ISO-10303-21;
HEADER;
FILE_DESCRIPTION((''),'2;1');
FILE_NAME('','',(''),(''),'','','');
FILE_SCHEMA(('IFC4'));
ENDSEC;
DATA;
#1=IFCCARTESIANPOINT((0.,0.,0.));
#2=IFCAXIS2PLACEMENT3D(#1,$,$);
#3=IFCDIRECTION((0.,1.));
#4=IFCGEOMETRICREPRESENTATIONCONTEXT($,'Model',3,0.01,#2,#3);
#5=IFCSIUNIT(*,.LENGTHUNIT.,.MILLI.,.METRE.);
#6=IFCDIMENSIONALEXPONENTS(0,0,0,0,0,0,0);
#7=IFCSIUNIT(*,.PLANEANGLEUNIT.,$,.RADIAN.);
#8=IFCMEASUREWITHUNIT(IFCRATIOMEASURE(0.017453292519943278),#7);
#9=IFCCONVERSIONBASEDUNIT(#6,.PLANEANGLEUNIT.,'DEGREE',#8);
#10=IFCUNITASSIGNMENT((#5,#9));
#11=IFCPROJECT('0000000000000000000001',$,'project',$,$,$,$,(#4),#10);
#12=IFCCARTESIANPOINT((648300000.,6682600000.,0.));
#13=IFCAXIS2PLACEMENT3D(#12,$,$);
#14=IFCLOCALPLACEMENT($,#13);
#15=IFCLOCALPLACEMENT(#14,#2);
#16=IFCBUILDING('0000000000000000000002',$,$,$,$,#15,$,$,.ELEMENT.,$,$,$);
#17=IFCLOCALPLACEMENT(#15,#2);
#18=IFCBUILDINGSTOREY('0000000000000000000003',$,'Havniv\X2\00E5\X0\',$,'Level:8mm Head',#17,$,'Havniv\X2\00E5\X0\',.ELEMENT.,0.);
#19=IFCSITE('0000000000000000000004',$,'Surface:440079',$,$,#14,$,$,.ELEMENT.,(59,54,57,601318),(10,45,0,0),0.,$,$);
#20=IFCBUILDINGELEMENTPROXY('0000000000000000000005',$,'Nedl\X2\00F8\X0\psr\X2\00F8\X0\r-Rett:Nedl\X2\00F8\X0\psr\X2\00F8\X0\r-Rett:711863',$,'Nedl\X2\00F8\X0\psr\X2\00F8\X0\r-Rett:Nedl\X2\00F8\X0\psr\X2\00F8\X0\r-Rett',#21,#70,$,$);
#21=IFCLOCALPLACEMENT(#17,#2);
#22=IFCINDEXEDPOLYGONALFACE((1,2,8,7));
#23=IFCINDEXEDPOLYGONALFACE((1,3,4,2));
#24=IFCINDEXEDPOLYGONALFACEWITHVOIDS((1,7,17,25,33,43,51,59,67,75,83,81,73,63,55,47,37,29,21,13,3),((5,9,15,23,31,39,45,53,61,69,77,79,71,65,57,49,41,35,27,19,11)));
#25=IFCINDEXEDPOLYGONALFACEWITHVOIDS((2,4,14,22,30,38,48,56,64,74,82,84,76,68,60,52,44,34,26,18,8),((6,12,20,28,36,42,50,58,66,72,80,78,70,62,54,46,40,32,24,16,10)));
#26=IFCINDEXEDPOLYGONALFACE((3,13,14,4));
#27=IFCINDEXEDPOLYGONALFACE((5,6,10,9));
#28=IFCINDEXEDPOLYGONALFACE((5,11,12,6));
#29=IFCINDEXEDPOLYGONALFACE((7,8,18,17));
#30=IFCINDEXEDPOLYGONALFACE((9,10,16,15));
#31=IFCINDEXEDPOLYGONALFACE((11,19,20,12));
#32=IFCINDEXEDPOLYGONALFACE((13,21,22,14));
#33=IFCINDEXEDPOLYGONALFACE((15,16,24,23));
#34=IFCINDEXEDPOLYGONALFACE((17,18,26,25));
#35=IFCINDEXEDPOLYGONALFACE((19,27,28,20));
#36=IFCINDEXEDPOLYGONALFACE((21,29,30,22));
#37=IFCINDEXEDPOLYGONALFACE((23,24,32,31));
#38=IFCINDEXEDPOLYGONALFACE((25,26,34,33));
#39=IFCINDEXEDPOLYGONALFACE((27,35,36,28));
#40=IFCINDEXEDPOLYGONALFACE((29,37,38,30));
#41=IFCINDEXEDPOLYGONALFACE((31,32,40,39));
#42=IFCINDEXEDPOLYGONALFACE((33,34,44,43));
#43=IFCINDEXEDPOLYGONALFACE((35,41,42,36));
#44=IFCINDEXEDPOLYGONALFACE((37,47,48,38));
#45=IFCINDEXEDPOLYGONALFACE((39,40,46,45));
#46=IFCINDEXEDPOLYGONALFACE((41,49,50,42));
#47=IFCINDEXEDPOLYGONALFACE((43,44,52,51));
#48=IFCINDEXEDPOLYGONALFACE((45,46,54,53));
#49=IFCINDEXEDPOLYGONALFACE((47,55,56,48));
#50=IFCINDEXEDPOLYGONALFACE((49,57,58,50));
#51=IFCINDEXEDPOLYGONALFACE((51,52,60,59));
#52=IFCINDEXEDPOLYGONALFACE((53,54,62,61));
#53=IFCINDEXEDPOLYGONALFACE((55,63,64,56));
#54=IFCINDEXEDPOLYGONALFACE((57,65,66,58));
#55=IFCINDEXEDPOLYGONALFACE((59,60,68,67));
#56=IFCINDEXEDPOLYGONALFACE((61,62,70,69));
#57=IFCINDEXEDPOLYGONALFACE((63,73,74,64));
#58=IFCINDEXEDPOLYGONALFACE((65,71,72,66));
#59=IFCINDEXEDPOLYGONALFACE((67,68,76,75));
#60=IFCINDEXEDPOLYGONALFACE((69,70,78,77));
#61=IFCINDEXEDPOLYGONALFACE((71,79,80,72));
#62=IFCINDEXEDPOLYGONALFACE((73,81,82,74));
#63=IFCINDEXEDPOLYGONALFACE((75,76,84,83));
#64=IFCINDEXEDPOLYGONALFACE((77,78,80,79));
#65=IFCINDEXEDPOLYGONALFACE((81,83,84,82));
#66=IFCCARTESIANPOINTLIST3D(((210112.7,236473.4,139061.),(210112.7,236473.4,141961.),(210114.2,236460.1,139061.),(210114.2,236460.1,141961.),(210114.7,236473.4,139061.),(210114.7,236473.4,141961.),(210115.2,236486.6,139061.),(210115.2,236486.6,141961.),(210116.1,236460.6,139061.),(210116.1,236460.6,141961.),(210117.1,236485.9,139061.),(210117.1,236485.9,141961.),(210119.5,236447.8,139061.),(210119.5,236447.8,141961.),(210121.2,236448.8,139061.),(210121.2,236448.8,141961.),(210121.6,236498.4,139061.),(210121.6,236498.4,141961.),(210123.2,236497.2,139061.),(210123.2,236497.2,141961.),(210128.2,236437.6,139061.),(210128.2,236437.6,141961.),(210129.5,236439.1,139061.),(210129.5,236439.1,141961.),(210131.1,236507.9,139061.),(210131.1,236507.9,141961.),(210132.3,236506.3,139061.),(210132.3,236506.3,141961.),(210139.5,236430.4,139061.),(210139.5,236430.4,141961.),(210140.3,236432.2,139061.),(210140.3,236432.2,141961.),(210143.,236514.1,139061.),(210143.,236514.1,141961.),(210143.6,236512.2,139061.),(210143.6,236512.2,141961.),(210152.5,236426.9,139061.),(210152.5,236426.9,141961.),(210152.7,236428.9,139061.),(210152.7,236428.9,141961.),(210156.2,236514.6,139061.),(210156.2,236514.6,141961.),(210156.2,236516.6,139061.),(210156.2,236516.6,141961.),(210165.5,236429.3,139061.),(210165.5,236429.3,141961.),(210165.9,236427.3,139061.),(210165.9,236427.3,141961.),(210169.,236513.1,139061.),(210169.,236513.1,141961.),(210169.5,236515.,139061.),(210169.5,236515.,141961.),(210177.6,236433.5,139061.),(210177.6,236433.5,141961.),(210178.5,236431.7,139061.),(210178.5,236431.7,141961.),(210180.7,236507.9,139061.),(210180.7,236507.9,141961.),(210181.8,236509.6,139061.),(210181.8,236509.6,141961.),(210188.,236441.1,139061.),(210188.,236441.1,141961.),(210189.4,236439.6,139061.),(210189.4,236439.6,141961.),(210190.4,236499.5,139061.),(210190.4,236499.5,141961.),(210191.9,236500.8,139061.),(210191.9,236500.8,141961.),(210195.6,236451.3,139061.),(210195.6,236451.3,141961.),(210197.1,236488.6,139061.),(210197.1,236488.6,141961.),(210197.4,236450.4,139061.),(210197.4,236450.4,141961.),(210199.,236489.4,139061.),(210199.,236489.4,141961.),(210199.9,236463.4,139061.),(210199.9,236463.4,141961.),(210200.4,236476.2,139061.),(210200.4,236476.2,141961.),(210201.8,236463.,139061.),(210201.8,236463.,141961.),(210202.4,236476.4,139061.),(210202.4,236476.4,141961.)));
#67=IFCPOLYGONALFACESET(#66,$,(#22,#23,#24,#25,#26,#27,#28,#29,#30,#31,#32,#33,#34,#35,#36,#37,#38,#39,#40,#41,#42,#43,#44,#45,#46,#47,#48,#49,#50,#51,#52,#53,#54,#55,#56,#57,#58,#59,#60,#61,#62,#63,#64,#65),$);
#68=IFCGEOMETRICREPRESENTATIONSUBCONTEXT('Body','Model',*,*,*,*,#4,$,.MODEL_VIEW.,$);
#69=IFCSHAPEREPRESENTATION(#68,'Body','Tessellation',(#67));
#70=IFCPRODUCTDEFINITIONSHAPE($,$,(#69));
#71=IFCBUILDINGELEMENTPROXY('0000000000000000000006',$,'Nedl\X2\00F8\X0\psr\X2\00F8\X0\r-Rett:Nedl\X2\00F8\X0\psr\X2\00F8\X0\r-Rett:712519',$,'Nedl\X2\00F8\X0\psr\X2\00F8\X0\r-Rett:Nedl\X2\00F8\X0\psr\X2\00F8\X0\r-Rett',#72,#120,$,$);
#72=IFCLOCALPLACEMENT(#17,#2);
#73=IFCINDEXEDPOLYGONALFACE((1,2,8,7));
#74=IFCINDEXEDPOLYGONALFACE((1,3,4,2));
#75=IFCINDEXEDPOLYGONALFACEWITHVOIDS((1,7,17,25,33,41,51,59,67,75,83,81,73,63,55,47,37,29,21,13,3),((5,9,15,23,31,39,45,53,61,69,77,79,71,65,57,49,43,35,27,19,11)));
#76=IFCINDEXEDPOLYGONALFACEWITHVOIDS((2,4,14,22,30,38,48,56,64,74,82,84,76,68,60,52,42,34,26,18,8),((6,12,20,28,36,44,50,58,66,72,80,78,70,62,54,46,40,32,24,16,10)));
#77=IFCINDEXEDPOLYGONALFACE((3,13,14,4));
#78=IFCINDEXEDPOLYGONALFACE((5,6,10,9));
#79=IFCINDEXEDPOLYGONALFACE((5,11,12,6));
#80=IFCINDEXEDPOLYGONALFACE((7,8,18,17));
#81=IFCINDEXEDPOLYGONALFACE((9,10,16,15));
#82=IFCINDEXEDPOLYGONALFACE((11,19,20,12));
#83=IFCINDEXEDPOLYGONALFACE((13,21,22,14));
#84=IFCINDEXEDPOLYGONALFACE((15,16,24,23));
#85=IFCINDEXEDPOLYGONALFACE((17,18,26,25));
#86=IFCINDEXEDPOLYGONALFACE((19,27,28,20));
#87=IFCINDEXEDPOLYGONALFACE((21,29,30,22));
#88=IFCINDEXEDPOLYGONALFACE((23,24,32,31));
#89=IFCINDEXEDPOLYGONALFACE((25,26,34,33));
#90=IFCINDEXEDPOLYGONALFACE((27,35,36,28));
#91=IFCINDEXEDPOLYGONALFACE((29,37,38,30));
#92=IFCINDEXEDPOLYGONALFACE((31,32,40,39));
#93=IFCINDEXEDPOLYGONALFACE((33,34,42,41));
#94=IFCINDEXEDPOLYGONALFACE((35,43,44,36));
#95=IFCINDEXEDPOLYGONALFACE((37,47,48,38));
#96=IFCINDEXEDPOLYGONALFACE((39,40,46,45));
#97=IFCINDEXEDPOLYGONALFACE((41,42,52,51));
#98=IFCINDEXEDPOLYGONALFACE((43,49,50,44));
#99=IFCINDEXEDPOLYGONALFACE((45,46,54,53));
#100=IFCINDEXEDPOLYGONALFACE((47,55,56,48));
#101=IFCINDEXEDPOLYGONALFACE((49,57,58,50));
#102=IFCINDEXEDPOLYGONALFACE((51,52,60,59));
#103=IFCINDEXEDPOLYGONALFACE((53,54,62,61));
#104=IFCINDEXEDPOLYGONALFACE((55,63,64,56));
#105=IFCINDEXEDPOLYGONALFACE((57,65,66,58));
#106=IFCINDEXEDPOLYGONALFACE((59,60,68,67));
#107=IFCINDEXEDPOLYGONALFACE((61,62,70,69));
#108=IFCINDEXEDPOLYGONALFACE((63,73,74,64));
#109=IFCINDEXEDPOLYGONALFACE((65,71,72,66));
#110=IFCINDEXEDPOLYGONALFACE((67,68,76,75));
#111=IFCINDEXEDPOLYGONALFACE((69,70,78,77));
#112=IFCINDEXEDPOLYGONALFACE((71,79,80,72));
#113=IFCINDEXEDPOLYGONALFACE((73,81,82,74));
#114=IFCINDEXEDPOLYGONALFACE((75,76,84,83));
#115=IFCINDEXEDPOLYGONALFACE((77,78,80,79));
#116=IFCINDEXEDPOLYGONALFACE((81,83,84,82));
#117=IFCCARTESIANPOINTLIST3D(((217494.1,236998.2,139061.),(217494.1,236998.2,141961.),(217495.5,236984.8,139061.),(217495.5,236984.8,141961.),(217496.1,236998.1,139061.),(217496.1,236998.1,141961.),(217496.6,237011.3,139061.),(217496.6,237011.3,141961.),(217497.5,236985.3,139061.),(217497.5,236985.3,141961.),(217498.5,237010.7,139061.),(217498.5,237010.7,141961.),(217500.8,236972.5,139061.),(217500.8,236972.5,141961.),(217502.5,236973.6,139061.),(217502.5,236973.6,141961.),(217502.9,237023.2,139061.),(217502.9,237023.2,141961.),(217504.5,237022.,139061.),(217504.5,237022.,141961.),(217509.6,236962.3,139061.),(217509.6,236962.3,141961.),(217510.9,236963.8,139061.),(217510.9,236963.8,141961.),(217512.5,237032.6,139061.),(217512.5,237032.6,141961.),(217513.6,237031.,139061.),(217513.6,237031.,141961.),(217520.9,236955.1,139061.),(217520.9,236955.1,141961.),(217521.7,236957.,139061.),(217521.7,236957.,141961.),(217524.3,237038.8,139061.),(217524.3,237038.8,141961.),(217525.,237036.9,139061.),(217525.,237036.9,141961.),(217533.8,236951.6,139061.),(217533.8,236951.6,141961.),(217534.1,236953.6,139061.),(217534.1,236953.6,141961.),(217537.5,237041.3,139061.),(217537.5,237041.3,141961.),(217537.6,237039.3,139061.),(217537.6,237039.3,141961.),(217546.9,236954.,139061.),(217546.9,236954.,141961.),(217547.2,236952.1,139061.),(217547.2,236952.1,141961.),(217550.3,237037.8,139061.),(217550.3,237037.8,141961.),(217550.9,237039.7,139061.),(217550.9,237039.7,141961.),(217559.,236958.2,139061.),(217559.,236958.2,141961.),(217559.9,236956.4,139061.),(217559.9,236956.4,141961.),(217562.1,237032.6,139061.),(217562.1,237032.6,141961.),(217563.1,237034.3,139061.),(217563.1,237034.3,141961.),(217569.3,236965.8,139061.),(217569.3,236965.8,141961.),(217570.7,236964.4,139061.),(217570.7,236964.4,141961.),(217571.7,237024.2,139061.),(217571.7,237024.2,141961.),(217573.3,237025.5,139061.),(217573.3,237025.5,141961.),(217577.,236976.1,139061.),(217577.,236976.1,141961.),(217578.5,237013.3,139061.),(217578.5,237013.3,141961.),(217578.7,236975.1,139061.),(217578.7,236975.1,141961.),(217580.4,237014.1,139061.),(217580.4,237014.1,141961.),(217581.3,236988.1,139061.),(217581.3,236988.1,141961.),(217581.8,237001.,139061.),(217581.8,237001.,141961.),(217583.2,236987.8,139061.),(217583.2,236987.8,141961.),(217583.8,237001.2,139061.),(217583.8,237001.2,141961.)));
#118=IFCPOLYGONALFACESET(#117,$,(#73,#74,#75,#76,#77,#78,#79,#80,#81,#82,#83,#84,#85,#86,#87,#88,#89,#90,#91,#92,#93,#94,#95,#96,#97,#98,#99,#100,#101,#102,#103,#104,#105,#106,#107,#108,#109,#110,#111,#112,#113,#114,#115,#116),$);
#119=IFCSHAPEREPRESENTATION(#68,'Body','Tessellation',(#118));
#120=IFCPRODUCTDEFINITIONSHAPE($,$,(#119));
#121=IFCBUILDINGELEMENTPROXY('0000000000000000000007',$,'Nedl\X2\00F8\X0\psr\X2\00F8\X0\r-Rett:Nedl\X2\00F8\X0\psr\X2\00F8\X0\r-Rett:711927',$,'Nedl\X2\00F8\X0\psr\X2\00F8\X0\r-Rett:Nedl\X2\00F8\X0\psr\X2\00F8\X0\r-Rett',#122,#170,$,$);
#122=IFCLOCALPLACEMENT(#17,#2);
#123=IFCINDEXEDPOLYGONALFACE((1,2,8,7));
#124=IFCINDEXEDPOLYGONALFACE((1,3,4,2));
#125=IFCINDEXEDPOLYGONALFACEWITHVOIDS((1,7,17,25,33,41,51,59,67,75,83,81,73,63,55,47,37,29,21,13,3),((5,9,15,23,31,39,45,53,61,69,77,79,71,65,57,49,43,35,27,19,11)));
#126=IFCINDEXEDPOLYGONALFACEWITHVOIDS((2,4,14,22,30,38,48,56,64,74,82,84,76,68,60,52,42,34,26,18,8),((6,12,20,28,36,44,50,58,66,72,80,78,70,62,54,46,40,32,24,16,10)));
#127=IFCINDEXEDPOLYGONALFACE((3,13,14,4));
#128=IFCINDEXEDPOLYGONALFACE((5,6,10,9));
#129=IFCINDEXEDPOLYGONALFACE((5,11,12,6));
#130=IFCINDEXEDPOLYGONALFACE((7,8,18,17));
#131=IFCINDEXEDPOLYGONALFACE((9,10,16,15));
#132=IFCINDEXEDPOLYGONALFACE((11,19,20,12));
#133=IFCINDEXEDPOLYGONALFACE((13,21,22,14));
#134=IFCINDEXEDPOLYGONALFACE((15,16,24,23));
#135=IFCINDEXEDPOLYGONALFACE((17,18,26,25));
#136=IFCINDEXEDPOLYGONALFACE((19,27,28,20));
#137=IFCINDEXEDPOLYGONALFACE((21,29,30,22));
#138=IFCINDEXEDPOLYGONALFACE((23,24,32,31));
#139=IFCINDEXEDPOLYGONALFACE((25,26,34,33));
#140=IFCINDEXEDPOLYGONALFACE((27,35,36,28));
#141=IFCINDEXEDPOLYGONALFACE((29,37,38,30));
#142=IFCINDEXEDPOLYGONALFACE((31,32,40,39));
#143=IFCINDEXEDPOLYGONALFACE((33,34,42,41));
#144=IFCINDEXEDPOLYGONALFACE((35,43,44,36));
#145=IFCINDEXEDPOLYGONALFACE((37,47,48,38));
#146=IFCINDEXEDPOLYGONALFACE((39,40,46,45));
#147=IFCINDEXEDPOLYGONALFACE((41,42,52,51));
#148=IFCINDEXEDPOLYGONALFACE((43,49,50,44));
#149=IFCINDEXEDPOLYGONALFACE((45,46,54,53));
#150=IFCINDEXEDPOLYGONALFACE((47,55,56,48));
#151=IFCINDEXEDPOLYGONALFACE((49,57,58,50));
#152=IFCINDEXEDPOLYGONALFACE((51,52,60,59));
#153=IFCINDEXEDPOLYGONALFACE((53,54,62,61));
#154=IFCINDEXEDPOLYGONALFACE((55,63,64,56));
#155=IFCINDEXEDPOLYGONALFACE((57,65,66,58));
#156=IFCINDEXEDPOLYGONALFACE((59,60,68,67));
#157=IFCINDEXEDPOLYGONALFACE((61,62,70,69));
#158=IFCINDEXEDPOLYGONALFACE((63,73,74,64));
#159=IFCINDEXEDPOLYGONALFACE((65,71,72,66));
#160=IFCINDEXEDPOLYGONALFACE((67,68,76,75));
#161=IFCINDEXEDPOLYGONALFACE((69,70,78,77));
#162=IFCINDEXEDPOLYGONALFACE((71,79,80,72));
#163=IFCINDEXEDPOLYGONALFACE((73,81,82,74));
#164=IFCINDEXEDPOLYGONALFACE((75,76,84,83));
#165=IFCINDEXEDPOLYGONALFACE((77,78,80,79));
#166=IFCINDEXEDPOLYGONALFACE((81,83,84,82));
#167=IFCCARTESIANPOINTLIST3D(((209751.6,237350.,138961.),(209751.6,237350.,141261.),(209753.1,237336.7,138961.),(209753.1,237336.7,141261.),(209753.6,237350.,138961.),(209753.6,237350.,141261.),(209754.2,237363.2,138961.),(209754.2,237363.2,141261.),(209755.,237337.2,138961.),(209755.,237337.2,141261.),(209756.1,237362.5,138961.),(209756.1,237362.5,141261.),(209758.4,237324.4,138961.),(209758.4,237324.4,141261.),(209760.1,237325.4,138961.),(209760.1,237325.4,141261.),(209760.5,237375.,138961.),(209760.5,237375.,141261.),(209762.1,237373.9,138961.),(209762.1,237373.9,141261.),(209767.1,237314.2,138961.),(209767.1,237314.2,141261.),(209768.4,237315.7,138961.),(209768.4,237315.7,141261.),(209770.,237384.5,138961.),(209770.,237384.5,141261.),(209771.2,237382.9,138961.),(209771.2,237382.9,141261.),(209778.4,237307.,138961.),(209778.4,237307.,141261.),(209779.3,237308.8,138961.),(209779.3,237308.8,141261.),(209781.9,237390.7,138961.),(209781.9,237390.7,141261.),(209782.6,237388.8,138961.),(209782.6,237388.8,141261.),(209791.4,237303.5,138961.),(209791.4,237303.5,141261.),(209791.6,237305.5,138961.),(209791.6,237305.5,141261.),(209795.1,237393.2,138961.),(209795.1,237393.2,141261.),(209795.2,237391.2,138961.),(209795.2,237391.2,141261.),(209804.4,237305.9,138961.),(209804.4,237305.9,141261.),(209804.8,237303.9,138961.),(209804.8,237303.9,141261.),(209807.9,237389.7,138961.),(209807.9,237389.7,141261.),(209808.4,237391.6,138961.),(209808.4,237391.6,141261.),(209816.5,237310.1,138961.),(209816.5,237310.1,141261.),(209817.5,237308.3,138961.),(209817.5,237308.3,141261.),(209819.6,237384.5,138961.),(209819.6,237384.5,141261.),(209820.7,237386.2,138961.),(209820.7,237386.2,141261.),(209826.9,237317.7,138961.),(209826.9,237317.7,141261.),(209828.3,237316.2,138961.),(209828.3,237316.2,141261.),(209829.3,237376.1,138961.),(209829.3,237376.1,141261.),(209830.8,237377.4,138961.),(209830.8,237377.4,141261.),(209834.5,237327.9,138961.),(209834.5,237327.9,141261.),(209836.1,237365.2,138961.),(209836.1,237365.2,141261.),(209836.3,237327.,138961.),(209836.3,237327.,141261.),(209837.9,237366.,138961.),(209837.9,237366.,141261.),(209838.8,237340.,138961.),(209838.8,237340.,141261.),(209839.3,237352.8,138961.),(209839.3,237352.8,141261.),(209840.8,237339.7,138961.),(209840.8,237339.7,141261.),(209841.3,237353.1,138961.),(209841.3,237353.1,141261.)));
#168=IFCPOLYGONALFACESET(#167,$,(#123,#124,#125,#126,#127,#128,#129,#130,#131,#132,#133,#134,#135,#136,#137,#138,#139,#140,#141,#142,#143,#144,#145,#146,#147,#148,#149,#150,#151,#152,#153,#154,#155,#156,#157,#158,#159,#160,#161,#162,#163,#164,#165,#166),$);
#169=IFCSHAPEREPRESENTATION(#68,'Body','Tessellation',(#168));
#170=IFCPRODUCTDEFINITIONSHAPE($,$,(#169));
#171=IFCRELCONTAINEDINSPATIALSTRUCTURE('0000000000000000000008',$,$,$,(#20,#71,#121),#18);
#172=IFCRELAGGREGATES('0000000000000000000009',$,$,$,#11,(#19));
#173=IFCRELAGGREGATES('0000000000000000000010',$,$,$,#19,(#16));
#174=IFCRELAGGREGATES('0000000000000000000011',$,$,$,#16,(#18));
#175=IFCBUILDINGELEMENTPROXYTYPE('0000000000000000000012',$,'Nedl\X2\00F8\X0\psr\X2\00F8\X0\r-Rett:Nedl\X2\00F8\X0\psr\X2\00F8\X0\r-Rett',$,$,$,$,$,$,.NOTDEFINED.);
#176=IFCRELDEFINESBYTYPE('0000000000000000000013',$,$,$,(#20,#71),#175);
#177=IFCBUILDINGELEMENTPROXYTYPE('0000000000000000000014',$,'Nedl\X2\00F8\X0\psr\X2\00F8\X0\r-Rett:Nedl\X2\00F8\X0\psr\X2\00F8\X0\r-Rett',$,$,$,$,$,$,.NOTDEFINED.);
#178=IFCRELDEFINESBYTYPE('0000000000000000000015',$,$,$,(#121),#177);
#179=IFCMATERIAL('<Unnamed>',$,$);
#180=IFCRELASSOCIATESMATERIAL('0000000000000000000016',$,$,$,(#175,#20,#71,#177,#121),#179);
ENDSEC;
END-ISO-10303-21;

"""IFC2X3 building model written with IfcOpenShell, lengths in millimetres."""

from ifc_helpers import new_model, entity, si_unit, converted_unit, direction, frame, frame_2d, origin, place, context, subcontext, project, spatial, hollow_circle, extrude, source, transform, mapped, material, type_object, type_shapes, element, save


model = new_model("IFC2X3")

# Units and contexts
model_context = context("Model", 3, precision=0.01, world=origin(), true_north=direction((0.0, 1.0)))
body_context = subcontext(model_context, "Body", "Model", "MODEL_VIEW")
ifc_project = project(units=[si_unit("LENGTHUNIT", "METRE", prefix="MILLI"), converted_unit("PLANEANGLEUNIT", "DEGREE", entity("IfcRatioMeasure", 0.017453292519943278), si_unit("PLANEANGLEUNIT", "RADIAN"), dimensions=[0, 0, 0, 0, 0, 0, 0])], contexts=[model_context])

# Site, building, storey
site_placement = place(None, frame((648300000.0, 6682600000.0, 0.0)))
site = spatial("IfcSite", under=ifc_project, at=site_placement, Name="Surface:440079", CompositionType="ELEMENT", RefLatitude=(59, 54, 57, 601318), RefLongitude=(10, 45, 0, 0), RefElevation=0.0)
building_placement = place(site_placement, origin())
building = spatial("IfcBuilding", under=site, at=building_placement, CompositionType="ELEMENT")
storey_placement = place(building_placement, origin())
storey = spatial("IfcBuildingStorey", under=building, at=storey_placement, Name="Havnivå", ObjectType="Level:8mm Head", LongName="Havnivå", CompositionType="ELEMENT", Elevation=0.0)

# Building element proxies
ifc_material_1 = material(Name="<Unnamed>")
building_element_proxy_type_1 = type_object("IfcBuildingElementProxyType", Name="Nedløpsrør-Rett:Nedløpsrør-Rett", PredefinedType="NOTDEFINED", material=ifc_material_1)
shared_shape_1 = source(origin(), body_context, "Body", "SweptSolid", [
    extrude(hollow_circle(Radius=45.0, WallThickness=2.0, at=frame_2d((0.0, 0.0), x_axis=(1.0, 0.0))), frame((0.0, 0.0, 0.0), z_axis=(0.0, 0.0, 1.0), x_axis=(-1.0, 0.0, 0.0)), (0.0, 0.0, 1.0), 2900.0),
])
type_shapes(building_element_proxy_type_1, [shared_shape_1])
for number, where, z_axis, x_axis, name in (
    (1, (210157.7, 236471.6, 139061.0), (0.0, 0.0, 1.0), (0.655187, 0.755467, 0.0), "Nedløpsrør-Rett:Nedløpsrør-Rett:711863"),
    (2, (217539.0, 236996.3, 139061.0), (0.0, 0.0, 1.0), (0.655187, 0.755467, 0.0), "Nedløpsrør-Rett:Nedløpsrør-Rett:712519"),
):
    element("IfcBuildingElementProxy", number, at=place(storey_placement, frame(where, z_axis=z_axis, x_axis=x_axis)), inside=storey, type_object=building_element_proxy_type_1, material=ifc_material_1, Name=name, ObjectType="Nedløpsrør-Rett:Nedløpsrør-Rett", context=body_context, shape_type="MappedRepresentation", body=[
        mapped(shared_shape_1, transform((0.0, 0.0, 0.0), scale=1.0)),
    ])
building_element_proxy_type_2 = type_object("IfcBuildingElementProxyType", Name="Nedløpsrør-Rett:Nedløpsrør-Rett", PredefinedType="NOTDEFINED", material=ifc_material_1)
shared_shape_2 = source(origin(), body_context, "Body", "SweptSolid", [
    extrude(hollow_circle(Radius=45.0, WallThickness=2.0, at=frame_2d((0.0, 0.0), x_axis=(1.0, 0.0))), frame((0.0, 0.0, 0.0), z_axis=(0.0, 0.0, 1.0), x_axis=(-1.0, 0.0, 0.0)), (0.0, 0.0, 1.0), 2300.0),
])
type_shapes(building_element_proxy_type_2, [shared_shape_2])
proxy_placement = place(storey_placement, frame((209796.6, 237348.2, 138961.0), z_axis=(0.0, 0.0, 1.0), x_axis=(0.655187, 0.755467, 0.0)))
element("IfcBuildingElementProxy", 3, at=proxy_placement, inside=storey, type_object=building_element_proxy_type_2, material=ifc_material_1, Name="Nedløpsrør-Rett:Nedløpsrør-Rett:711927", ObjectType="Nedløpsrør-Rett:Nedløpsrør-Rett", context=body_context, shape_type="MappedRepresentation", body=[
    mapped(shared_shape_2, transform((0.0, 0.0, 0.0), scale=1.0)),
])

save(model, "model.ifc")
